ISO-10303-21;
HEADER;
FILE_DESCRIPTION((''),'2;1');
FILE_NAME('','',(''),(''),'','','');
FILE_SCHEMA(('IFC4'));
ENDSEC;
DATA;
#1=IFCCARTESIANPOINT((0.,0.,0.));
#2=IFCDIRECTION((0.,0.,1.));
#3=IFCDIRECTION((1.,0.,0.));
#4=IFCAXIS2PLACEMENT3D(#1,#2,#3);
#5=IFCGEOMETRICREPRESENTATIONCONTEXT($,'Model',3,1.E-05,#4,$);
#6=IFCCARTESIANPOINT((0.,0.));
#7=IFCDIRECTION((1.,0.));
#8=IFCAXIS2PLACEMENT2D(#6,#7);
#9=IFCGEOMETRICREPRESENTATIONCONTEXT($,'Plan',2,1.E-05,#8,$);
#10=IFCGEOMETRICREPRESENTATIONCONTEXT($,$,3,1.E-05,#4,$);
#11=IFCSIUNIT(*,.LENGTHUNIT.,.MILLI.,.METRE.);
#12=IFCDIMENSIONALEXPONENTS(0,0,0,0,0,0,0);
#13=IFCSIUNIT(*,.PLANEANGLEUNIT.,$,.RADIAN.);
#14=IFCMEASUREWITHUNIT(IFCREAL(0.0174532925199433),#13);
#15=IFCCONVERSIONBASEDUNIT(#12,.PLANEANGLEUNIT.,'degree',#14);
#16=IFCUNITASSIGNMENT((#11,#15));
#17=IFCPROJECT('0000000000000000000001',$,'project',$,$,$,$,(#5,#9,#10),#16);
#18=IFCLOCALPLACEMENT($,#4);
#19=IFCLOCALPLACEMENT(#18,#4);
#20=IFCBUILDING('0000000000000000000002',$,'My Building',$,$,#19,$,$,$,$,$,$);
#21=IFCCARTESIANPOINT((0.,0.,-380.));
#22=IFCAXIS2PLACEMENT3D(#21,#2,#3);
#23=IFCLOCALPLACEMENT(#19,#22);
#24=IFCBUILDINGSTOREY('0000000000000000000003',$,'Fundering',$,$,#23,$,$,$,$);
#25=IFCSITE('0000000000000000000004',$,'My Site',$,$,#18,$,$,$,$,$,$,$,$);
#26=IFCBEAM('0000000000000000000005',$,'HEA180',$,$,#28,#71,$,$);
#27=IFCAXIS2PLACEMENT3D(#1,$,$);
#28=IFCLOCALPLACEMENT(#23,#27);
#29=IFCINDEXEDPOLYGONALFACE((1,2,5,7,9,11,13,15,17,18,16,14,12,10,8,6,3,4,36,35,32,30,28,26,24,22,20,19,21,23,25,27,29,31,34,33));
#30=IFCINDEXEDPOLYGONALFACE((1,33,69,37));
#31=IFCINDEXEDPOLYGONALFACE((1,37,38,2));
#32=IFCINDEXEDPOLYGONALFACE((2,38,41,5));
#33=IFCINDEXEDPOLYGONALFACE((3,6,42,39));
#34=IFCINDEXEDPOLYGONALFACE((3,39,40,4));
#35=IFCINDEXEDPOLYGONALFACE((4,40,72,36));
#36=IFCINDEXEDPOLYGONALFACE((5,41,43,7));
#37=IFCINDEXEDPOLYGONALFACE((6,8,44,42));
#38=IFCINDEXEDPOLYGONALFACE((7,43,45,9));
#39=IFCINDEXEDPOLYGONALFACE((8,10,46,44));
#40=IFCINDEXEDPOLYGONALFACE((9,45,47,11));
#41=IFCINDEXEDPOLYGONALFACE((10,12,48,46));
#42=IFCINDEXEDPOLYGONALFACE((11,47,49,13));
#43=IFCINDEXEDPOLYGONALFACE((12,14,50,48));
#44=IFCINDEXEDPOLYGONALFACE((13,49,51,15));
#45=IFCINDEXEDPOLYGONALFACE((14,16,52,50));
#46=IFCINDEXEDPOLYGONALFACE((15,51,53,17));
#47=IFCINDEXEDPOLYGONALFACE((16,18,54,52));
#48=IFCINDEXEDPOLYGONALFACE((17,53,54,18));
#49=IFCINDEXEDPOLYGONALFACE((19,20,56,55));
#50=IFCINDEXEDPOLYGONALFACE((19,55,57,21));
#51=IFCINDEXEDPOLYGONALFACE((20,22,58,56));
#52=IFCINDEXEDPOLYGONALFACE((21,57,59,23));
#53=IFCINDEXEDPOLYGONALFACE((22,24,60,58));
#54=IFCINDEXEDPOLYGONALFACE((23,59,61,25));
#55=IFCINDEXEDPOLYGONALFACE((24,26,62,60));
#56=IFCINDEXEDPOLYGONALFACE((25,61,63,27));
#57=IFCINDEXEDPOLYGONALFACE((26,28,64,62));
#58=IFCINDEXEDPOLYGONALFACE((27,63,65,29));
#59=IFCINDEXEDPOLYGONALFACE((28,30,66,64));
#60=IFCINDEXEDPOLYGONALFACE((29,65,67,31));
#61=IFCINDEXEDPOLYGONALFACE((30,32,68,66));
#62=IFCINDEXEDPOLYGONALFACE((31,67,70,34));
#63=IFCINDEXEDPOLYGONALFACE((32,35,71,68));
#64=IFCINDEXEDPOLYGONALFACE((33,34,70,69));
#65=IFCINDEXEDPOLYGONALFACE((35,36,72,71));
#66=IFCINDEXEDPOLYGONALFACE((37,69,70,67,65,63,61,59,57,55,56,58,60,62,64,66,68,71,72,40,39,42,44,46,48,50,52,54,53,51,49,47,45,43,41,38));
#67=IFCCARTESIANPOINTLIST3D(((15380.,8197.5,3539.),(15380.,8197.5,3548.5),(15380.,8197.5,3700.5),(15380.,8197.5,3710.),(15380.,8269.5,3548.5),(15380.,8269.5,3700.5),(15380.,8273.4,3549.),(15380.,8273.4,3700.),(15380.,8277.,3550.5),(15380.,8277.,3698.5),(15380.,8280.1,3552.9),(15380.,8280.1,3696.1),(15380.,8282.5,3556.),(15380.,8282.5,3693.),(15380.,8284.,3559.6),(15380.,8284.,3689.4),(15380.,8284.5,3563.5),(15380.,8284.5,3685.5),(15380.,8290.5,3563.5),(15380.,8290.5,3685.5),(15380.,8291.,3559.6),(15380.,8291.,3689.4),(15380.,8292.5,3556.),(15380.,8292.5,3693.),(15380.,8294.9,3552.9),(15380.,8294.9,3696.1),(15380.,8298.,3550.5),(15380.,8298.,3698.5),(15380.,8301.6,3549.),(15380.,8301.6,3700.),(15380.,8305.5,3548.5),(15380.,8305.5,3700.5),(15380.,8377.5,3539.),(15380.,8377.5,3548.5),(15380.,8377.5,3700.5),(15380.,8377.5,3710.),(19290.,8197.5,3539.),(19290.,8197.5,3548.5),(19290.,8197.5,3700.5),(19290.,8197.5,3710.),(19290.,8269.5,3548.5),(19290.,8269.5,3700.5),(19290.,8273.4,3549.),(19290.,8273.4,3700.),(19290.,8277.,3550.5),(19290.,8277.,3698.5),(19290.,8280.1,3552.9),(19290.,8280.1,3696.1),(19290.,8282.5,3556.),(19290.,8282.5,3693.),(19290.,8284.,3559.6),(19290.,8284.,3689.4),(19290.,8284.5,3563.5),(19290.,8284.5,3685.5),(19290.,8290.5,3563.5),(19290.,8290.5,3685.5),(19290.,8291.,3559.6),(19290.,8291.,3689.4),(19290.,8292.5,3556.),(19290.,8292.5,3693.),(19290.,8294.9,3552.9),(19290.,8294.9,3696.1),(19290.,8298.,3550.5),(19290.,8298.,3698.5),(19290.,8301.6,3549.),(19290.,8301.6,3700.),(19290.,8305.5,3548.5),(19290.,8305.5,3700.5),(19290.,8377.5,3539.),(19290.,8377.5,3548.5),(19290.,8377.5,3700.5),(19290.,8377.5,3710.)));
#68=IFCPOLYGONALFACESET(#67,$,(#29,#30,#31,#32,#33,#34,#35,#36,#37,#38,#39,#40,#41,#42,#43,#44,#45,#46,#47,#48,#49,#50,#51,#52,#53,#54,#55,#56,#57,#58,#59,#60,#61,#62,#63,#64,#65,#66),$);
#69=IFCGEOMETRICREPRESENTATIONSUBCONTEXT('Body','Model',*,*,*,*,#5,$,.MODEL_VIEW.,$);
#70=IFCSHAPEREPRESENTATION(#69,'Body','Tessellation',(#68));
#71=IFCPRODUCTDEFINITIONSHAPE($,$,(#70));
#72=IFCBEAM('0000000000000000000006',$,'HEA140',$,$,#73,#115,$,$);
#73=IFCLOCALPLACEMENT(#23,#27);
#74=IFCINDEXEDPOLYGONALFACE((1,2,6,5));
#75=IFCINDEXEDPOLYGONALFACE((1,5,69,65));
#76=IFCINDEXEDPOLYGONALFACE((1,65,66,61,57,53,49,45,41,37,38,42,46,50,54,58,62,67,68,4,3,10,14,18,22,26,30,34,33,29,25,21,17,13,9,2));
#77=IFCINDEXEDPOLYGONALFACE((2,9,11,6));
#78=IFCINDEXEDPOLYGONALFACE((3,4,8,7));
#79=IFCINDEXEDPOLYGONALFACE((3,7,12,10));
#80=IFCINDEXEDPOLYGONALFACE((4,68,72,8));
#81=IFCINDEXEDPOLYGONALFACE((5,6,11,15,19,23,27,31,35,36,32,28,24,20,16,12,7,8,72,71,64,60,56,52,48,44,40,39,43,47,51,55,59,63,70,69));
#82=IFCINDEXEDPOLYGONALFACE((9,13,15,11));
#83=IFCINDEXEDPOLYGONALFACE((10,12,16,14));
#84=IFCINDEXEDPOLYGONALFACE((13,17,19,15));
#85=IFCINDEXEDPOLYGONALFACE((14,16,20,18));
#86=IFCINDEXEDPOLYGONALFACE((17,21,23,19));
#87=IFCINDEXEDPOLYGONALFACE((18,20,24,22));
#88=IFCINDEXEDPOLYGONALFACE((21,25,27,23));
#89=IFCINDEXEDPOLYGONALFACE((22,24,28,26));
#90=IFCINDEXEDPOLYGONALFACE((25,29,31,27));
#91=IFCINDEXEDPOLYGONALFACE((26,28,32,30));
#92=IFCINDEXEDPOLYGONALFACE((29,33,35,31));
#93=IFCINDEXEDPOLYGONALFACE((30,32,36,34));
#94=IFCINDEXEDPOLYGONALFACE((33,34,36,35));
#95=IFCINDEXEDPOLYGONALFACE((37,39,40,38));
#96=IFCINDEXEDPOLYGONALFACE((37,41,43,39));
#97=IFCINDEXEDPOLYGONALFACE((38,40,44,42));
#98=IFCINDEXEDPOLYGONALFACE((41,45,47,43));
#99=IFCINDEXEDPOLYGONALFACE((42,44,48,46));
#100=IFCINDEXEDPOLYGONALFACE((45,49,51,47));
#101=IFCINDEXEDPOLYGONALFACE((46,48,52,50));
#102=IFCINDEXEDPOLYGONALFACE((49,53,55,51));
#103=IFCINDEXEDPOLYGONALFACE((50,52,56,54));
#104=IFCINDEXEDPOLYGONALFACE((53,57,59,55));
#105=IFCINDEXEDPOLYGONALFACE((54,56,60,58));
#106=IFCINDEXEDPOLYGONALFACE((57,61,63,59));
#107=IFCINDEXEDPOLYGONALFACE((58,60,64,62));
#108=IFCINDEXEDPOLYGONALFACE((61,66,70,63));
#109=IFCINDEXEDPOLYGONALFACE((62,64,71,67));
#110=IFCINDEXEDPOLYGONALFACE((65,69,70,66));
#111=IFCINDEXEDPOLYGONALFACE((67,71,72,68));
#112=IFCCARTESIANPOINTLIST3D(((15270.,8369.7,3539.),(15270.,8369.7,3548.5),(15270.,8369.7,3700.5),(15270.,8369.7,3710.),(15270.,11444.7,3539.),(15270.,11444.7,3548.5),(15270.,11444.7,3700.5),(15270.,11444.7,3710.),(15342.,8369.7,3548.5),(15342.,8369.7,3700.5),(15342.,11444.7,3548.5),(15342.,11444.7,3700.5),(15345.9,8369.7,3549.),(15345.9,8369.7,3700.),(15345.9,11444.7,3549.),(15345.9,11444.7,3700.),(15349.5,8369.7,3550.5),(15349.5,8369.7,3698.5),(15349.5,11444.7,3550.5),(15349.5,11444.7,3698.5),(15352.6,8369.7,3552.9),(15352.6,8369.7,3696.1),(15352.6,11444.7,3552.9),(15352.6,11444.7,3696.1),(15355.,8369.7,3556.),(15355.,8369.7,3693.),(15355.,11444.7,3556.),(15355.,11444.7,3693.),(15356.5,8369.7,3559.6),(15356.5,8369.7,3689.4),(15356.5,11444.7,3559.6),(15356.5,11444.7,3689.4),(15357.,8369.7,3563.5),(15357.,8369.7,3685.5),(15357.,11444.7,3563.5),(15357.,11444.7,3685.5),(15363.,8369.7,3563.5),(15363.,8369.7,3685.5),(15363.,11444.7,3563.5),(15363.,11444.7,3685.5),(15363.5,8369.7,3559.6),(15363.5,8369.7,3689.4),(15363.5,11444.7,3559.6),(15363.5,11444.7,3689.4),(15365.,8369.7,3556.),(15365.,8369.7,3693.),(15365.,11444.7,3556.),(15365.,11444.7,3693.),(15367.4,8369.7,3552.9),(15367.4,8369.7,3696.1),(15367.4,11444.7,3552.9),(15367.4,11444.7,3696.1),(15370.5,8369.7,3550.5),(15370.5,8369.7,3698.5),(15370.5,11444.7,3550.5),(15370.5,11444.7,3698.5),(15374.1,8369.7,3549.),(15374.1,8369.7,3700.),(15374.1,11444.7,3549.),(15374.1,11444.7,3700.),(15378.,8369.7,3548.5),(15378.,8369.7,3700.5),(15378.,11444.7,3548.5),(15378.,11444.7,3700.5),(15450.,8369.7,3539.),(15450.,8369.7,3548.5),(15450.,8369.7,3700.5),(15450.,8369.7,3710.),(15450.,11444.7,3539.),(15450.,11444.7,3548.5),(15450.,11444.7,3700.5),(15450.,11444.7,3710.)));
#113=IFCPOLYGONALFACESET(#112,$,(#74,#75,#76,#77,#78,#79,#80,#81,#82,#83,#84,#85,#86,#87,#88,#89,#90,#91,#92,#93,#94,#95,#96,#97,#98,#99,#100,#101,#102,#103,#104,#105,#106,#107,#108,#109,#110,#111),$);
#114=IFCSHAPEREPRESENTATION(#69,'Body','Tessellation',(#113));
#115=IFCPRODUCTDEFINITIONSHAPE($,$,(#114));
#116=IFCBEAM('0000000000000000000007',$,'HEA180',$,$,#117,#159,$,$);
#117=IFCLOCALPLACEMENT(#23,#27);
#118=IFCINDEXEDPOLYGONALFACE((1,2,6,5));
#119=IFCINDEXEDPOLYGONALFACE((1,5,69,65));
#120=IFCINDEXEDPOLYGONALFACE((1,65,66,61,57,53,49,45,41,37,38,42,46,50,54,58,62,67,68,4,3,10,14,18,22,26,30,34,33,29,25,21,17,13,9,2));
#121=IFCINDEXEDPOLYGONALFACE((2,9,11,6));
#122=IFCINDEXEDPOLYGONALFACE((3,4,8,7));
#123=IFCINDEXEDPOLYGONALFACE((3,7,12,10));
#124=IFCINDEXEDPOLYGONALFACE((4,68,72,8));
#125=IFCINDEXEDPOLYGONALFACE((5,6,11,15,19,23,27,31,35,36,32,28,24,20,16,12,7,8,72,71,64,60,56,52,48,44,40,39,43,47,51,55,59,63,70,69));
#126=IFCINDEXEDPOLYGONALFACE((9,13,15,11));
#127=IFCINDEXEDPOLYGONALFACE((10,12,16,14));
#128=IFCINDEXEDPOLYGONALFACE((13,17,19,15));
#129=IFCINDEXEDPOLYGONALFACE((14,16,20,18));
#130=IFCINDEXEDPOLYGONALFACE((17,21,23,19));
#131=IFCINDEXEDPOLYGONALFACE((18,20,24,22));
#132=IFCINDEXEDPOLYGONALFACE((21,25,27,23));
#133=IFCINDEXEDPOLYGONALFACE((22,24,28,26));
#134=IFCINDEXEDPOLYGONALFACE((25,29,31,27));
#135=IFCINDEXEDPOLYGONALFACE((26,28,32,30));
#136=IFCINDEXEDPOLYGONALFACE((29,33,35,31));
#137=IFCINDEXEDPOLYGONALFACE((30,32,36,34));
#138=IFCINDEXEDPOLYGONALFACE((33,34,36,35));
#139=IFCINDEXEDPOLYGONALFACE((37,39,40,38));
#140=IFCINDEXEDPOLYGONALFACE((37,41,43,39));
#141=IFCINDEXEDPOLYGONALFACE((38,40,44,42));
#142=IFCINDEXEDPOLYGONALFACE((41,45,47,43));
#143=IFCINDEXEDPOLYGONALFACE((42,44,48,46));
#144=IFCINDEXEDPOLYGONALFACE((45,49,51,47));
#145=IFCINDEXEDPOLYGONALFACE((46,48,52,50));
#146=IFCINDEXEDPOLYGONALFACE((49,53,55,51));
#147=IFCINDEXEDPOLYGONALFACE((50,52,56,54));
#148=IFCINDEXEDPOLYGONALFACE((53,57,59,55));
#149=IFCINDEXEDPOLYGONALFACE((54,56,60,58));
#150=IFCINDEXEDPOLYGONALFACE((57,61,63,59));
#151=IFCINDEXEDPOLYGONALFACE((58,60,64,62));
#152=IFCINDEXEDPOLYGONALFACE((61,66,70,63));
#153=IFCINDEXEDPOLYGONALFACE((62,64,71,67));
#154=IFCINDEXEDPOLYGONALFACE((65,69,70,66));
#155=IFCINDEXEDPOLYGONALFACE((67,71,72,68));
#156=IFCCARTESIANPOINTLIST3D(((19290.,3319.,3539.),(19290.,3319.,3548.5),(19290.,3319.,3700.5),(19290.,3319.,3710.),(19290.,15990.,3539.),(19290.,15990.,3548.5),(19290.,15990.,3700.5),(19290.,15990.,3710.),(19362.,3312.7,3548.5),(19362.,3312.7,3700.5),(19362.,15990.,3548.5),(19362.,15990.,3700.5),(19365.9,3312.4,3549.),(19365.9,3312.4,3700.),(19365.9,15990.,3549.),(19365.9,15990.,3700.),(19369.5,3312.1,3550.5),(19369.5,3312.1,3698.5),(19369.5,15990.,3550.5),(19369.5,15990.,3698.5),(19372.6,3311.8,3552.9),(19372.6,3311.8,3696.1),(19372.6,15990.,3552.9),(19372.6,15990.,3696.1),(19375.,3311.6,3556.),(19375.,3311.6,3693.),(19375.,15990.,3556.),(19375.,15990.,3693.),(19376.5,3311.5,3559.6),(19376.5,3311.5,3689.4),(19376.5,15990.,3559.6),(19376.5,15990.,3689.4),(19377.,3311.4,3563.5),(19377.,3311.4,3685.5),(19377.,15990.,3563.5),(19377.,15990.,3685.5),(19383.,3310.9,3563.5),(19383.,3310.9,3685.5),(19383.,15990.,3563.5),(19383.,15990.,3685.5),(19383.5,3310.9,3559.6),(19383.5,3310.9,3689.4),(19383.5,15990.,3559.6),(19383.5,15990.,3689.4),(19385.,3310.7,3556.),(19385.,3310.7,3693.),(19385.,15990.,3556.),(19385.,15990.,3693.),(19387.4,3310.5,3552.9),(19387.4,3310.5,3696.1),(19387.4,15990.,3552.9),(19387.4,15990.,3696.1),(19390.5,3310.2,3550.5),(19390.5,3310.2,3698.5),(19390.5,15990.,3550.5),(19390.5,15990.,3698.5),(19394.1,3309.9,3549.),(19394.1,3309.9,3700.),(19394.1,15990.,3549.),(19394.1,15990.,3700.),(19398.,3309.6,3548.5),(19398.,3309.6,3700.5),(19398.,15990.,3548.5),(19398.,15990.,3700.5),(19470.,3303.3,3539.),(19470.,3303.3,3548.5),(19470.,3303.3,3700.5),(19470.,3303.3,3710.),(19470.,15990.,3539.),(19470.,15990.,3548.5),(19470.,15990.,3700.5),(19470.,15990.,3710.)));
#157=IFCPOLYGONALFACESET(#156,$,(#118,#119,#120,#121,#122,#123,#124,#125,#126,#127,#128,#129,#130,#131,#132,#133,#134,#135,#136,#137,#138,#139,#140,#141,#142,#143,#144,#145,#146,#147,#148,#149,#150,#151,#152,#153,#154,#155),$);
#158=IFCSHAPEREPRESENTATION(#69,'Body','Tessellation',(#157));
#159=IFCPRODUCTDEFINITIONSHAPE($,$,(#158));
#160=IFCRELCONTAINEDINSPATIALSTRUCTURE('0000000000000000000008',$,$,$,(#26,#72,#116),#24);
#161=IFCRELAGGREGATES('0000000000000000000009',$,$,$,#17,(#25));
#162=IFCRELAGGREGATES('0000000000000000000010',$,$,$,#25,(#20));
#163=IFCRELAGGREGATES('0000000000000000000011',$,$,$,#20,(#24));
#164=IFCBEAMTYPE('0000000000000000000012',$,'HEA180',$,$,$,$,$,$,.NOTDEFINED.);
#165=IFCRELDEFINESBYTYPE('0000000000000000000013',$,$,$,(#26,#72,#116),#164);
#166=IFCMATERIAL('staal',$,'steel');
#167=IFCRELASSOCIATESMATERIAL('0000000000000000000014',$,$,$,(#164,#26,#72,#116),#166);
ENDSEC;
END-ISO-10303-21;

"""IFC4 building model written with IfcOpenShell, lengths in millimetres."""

from ifc_helpers import new_model, entity, si_unit, converted_unit, frame, origin_with_axes, origin_2d_with_axis, place, context, subcontext, project, spatial, i_section, extrude, clip, halfspace, material, material_profile, profile_set, profile_usage, type_object, element, save


model = new_model("IFC4")

# Units and contexts
model_context = context("Model", 3, precision=1e-05, world=origin_with_axes())
plan_context = context("Plan", 2, precision=1e-05, world=origin_2d_with_axis())
context_of_model = context(None, 3, precision=1e-05, world=origin_with_axes())
body_context = subcontext(model_context, "Body", "Model", "MODEL_VIEW")
ifc_project = project(units=[si_unit("LENGTHUNIT", "METRE", prefix="MILLI"), converted_unit("PLANEANGLEUNIT", "degree", entity("IfcReal", 0.0174532925199433), si_unit("PLANEANGLEUNIT", "RADIAN"), dimensions=[0, 0, 0, 0, 0, 0, 0])], contexts=[model_context, plan_context, context_of_model])

# Site, building, storey
site_placement = place(None, origin_with_axes())
site = spatial("IfcSite", under=ifc_project, at=site_placement, Name="My Site")
building_placement = place(site_placement, origin_with_axes())
building = spatial("IfcBuilding", under=site, at=building_placement, Name="My Building")
storey_placement = place(building_placement, frame((0.0, 0.0, -380.0), z_axis=(0.0, 0.0, 1.0), x_axis=(1.0, 0.0, 0.0)))
storey = spatial("IfcBuildingStorey", under=building, at=storey_placement, Name="Fundering")

# Shared definitions
ifc_material_1 = material(Name="staal", Category="steel")

# Beams
ifc_material_profile_1 = material_profile(ifc_material_1, i_section(OverallWidth=180.0, OverallDepth=171.0, WebThickness=6.0, FlangeThickness=9.5, FilletRadius=15.0))
ifc_profile_set_1 = profile_set([ifc_material_profile_1], Name="HEA180")
beam_type_1 = type_object("IfcBeamType", Name="HEA180", PredefinedType="NOTDEFINED", material=ifc_profile_set_1)
ifc_profile_usage_1 = profile_usage(ifc_profile_set_1)
beam_1_placement = place(storey_placement, frame((15380.0, 8287.5, 3624.5), z_axis=(1.0, 0.0, 0.0), x_axis=(0.0, 1.0, 0.0)))
element("IfcBeam", 1, at=beam_1_placement, inside=storey, type_object=beam_type_1, material=ifc_profile_usage_1, Name="HEA180", context=body_context, shape_type="SweptSolid", body=[
    extrude(i_section(OverallWidth=180.0, OverallDepth=171.0, WebThickness=6.0, FlangeThickness=9.5, FilletRadius=15.0), origin_with_axes(), (0.0, 0.0, 1.0), 3910.0),
])
ifc_profile_usage_2 = profile_usage(ifc_profile_set_1)
beam_2_placement = place(storey_placement, frame((15360.0, 8369.7, 3624.5), z_axis=(0.0, 1.0, 0.0), x_axis=(-1.0, 0.0, 0.0)))
element("IfcBeam", 2, at=beam_2_placement, inside=storey, type_object=beam_type_1, material=ifc_profile_usage_2, Name="HEA140", context=body_context, shape_type="SweptSolid", body=[
    extrude(i_section(OverallWidth=180.0, OverallDepth=171.0, WebThickness=6.0, FlangeThickness=9.5, FilletRadius=15.0), origin_with_axes(), (0.0, 0.0, 1.0), 3075.0),
])
ifc_profile_usage_3 = profile_usage(ifc_profile_set_1)
beam_3_placement = place(storey_placement, frame((19380.0, 15990.0, 3624.5), z_axis=(0.0, -1.0, 0.0), x_axis=(1.0, 0.0, 0.0)))
element("IfcBeam", 3, at=beam_3_placement, inside=storey, type_object=beam_type_1, material=ifc_profile_usage_3, Name="HEA180", context=body_context, shape_type="Clipping", body=[
    clip(extrude(i_section(OverallWidth=180.0, OverallDepth=171.0, WebThickness=6.0, FlangeThickness=9.5, FilletRadius=15.0), origin_with_axes(), (0.0, 0.0, 1.0), 13377.1), halfspace(frame((90.0, -3244.5, 12686.7), z_axis=(-0.087123, 0.0, 0.996198), x_axis=(-0.000001, 1.0, 0.0)), False)),
])

save(model, "model.ifc")
